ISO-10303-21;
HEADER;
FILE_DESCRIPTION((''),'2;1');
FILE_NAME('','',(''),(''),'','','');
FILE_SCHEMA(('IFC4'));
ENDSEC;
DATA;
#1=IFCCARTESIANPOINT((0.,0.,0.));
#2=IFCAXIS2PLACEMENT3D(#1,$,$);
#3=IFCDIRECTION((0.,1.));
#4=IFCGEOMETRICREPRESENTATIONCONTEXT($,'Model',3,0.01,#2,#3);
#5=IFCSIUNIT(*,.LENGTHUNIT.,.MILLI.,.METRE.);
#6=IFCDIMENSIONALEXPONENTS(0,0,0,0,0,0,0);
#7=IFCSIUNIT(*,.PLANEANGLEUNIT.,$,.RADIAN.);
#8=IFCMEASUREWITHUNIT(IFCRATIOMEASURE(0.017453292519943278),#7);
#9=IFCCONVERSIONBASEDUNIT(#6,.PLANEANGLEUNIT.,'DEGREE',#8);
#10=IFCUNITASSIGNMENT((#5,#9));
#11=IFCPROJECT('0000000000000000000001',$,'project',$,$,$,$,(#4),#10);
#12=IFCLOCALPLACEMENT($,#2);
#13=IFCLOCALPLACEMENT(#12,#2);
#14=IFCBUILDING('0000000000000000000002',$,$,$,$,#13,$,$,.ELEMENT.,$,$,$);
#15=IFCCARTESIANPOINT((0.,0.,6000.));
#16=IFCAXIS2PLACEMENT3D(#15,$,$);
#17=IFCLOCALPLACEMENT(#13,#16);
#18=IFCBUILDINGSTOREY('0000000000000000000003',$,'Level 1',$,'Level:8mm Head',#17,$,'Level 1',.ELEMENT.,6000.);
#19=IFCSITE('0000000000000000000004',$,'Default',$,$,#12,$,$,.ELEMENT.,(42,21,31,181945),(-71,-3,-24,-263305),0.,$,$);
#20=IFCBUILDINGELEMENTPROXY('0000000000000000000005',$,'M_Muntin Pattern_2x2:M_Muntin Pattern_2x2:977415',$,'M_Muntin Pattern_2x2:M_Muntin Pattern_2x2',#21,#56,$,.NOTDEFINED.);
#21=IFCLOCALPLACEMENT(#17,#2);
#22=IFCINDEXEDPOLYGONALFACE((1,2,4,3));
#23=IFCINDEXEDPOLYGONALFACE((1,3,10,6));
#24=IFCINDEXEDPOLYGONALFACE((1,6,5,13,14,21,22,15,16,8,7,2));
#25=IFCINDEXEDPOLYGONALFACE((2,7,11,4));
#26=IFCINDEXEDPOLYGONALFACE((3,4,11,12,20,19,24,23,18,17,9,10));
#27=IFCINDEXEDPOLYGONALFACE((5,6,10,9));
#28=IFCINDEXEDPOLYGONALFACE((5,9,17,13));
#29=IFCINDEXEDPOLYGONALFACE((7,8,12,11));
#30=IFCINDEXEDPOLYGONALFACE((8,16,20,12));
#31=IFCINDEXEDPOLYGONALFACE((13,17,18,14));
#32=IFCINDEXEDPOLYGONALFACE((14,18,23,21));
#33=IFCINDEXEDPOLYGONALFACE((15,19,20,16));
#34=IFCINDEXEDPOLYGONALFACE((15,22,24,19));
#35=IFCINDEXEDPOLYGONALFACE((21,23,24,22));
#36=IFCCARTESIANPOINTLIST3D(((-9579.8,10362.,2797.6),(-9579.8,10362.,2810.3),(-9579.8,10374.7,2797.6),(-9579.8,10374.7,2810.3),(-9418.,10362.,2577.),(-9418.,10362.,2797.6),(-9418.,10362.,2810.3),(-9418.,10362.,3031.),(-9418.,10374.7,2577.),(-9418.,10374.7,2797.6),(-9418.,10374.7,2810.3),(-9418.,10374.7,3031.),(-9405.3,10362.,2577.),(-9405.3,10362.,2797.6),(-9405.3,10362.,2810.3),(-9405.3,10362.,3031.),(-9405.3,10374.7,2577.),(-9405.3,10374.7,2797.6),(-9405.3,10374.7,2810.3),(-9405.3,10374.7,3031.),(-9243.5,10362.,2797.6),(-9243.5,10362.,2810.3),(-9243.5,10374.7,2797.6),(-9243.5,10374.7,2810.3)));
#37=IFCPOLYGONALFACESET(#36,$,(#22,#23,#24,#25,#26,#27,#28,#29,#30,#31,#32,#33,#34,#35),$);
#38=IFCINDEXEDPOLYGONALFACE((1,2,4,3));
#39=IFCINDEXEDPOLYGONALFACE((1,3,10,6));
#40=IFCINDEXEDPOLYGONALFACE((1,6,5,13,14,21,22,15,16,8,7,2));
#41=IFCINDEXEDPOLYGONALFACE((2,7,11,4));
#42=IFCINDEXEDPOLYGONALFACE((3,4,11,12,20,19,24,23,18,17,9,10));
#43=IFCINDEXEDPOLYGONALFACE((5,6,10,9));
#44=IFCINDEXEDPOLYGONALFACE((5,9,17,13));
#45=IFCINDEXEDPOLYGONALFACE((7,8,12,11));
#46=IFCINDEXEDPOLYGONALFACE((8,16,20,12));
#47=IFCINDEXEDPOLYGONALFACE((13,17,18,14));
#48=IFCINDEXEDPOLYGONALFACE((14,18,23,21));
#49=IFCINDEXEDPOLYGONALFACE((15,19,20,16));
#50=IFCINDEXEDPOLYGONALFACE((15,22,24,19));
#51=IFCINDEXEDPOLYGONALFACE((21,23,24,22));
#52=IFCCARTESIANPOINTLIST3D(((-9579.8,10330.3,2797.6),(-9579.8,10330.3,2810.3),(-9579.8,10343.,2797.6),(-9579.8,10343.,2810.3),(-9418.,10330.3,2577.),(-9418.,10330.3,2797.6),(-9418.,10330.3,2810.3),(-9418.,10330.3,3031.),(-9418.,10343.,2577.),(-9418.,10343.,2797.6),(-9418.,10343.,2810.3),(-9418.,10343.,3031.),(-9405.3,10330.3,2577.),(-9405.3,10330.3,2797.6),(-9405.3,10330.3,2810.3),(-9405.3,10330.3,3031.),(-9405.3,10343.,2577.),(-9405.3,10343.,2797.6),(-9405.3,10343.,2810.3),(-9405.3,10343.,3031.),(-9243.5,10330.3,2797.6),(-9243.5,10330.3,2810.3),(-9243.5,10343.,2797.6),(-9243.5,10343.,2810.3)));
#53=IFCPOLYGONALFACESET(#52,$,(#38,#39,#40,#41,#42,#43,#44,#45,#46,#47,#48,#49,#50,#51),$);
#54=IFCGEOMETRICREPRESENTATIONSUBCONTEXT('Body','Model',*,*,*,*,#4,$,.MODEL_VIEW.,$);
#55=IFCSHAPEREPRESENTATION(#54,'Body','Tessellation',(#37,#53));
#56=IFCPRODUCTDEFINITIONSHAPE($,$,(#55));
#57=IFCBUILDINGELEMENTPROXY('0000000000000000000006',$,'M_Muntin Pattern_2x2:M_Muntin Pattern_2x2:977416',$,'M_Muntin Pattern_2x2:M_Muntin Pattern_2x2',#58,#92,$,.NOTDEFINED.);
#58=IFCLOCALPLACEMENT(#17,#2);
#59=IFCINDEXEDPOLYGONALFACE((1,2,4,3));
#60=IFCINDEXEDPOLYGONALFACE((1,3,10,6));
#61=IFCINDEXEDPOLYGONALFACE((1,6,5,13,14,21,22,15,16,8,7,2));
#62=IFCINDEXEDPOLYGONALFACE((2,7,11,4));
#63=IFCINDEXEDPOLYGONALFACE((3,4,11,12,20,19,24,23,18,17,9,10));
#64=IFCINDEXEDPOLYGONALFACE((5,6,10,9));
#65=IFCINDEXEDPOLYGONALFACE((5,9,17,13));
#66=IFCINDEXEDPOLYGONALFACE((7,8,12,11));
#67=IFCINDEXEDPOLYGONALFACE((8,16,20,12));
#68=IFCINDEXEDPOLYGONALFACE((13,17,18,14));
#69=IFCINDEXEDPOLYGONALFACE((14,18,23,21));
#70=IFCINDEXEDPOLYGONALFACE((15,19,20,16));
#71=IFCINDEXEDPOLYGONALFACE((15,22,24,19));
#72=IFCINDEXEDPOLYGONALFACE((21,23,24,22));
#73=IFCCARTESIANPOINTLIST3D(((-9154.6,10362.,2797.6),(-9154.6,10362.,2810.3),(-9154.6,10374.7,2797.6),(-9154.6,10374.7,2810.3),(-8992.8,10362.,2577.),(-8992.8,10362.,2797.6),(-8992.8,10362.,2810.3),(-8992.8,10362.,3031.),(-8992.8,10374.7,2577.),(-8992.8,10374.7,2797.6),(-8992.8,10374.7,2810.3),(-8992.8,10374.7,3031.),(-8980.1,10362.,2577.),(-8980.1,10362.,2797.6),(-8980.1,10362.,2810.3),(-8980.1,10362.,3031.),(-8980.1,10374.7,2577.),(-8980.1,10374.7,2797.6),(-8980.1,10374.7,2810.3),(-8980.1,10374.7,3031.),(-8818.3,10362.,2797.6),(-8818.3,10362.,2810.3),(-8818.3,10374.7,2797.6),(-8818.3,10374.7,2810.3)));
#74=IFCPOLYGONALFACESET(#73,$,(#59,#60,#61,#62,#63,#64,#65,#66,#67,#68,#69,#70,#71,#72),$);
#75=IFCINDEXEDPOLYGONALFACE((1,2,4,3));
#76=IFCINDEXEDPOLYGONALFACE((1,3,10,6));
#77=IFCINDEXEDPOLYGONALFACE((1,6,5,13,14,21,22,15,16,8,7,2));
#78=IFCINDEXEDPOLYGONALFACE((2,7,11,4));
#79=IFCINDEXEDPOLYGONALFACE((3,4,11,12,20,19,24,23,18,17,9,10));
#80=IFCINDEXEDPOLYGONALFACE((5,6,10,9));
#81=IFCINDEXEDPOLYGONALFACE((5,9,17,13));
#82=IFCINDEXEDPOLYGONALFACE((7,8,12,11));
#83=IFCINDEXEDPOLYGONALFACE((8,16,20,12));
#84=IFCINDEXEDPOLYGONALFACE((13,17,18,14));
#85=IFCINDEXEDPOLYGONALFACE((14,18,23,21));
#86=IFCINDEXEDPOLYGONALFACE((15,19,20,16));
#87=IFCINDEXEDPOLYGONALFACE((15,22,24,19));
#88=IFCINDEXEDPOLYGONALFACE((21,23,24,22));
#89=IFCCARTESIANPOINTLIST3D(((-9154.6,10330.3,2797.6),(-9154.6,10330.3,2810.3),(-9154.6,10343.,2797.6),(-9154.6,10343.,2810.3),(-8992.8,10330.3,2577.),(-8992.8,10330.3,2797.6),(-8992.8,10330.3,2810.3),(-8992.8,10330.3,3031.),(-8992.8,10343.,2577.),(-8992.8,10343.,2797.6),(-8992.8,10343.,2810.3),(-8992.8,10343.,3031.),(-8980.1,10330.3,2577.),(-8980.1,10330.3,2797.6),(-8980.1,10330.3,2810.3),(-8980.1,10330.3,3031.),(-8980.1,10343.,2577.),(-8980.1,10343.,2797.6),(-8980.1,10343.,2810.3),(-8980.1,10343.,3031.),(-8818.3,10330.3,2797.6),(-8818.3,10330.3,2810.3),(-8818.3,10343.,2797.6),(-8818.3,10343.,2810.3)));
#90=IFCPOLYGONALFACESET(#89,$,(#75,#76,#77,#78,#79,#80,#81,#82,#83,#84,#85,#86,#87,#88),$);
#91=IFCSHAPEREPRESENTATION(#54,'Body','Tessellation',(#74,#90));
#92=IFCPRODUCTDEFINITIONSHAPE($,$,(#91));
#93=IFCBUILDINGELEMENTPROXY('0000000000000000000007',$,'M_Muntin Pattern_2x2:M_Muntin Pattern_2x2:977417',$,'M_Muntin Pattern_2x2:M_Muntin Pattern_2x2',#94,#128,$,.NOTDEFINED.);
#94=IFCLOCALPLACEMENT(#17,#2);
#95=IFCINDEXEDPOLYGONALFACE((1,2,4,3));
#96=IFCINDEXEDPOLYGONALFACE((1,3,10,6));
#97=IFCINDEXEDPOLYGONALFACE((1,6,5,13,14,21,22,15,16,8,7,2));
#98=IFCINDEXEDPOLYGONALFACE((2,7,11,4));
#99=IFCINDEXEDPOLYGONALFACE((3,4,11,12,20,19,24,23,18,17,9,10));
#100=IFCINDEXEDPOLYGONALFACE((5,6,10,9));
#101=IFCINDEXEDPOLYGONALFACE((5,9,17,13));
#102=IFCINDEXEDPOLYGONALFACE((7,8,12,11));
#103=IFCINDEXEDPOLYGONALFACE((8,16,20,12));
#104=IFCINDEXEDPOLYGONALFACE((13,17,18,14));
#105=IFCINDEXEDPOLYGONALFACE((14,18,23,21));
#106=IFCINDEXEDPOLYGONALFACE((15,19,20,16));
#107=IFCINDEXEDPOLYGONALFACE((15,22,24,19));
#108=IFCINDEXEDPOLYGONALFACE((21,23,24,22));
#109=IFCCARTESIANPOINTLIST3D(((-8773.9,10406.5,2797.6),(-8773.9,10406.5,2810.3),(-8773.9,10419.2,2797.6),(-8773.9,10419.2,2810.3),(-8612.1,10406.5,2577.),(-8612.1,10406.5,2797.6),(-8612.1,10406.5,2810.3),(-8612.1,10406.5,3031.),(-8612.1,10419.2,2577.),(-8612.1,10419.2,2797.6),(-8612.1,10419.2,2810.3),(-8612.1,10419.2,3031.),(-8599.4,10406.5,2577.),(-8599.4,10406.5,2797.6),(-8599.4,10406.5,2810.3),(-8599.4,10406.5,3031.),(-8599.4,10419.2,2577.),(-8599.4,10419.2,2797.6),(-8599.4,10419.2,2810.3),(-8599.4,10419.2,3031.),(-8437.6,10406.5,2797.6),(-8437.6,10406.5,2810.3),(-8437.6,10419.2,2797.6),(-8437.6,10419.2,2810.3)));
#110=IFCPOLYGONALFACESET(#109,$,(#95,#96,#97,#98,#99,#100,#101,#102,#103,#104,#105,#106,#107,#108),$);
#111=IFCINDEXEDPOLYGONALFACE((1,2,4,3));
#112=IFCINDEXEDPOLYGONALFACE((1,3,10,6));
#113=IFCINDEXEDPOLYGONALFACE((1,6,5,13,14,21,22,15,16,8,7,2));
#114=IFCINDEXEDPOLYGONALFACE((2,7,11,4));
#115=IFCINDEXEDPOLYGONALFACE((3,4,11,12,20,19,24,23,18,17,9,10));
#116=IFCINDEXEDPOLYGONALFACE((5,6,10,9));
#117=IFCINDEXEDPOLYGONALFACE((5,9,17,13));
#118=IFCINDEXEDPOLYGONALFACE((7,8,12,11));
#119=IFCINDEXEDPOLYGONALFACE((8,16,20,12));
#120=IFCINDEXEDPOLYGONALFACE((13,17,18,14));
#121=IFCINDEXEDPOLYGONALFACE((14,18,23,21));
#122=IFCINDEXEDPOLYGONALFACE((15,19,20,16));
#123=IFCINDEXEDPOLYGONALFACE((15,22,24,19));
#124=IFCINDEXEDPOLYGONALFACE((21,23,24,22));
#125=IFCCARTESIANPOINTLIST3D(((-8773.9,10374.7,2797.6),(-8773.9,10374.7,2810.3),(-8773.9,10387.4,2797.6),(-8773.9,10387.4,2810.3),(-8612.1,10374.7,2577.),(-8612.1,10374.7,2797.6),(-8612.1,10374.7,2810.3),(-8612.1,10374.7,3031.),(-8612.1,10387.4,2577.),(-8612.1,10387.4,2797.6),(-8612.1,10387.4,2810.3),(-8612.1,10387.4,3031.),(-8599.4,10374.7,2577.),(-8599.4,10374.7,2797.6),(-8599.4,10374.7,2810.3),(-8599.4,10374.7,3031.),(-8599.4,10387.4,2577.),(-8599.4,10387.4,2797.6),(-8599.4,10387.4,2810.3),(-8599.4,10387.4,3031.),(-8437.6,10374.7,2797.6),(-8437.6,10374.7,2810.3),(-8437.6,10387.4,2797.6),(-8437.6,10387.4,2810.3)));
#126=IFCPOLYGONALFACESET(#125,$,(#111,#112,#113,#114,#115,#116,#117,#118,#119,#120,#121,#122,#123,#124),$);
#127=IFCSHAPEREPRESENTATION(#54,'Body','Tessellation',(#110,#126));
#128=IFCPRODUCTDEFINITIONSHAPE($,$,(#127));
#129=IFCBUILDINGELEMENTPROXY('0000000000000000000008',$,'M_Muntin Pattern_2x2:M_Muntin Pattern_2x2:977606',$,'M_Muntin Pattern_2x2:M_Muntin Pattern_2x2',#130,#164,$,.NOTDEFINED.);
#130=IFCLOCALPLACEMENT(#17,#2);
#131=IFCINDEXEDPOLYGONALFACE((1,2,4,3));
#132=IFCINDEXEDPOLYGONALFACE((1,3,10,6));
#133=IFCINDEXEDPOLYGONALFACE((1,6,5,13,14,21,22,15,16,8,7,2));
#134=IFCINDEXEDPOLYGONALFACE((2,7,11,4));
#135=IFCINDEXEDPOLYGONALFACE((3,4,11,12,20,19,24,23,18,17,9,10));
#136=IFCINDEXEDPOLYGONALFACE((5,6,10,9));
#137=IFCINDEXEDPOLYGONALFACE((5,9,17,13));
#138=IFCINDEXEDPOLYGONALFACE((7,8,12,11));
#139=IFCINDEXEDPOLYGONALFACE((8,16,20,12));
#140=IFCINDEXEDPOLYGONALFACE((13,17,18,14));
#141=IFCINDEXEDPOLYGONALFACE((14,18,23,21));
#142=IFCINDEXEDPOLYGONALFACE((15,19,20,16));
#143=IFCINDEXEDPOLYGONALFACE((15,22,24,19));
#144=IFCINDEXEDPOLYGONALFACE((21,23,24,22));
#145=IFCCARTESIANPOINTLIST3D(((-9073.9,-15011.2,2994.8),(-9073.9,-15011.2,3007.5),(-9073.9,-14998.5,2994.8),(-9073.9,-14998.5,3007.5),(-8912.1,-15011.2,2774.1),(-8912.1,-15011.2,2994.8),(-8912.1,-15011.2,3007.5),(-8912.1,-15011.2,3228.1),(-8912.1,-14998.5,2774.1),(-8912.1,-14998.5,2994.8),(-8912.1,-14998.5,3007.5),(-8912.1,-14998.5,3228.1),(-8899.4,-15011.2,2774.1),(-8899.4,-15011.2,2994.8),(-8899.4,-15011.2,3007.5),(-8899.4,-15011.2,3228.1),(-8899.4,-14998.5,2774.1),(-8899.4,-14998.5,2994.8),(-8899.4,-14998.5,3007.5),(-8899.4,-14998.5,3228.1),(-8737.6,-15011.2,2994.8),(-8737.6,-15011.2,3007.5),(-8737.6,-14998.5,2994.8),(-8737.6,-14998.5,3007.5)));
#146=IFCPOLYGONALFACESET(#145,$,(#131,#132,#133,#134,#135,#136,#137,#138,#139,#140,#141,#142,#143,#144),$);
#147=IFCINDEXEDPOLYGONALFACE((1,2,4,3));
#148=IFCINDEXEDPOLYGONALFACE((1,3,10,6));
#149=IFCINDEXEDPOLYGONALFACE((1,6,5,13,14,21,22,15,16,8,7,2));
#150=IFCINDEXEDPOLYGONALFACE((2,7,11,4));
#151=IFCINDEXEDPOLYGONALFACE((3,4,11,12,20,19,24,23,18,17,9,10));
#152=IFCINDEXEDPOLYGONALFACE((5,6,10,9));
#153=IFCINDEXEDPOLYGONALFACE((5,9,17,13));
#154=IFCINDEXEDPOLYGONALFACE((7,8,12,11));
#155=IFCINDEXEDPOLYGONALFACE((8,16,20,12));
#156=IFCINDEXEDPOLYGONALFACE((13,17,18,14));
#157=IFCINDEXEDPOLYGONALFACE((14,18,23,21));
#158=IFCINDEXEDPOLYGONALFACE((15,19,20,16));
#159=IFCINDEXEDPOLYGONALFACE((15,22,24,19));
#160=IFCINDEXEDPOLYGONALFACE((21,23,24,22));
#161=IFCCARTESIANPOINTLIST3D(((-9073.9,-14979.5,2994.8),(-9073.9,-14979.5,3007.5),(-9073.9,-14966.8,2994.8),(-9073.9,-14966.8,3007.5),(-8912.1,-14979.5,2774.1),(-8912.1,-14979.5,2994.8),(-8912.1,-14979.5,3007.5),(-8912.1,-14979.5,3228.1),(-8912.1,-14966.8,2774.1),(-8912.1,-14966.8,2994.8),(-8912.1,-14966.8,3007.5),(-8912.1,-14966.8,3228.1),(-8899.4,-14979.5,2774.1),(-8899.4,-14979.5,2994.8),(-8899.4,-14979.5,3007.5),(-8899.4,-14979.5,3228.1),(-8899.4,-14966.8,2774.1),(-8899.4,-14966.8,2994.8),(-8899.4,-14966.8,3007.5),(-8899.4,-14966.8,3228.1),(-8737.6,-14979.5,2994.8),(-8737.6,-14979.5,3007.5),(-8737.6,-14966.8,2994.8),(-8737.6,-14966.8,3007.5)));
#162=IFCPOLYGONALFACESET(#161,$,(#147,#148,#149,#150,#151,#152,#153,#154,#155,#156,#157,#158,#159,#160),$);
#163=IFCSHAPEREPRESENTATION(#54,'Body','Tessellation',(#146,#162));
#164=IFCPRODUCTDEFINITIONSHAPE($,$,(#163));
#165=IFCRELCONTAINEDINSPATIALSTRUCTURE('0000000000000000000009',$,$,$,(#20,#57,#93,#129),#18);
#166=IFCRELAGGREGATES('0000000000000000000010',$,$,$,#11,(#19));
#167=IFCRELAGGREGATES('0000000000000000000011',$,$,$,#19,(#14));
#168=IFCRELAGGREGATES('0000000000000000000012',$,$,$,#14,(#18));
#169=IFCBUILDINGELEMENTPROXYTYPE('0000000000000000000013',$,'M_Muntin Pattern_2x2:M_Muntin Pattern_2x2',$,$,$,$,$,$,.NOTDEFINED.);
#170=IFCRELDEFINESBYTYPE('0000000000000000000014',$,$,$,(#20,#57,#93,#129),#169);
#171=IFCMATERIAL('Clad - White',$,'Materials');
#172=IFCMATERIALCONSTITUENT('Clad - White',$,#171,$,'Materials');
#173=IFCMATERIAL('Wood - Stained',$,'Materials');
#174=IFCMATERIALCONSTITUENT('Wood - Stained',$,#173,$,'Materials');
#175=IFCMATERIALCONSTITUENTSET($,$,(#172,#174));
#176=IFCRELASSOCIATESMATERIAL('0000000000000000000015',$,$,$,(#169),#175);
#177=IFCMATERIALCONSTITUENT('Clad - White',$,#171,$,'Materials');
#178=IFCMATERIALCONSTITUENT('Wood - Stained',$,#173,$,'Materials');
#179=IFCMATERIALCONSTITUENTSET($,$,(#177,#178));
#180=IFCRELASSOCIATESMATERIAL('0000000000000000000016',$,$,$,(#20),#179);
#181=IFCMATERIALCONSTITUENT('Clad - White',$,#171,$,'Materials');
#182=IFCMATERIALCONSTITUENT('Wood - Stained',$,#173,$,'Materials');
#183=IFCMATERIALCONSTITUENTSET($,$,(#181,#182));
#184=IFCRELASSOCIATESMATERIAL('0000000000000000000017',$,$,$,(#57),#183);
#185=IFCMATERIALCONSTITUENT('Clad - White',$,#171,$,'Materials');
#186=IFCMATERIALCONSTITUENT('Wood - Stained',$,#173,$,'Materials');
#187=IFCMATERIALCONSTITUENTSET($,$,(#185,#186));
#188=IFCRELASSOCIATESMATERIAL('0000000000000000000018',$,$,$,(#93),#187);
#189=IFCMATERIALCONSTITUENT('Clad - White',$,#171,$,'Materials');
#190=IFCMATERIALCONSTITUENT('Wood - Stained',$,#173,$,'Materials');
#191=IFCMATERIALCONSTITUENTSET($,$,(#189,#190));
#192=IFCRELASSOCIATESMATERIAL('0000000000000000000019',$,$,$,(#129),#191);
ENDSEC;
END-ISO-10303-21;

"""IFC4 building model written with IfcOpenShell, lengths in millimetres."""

from ifc_helpers import new_model, entity, si_unit, converted_unit, direction, frame, origin, place, context, subcontext, project, spatial, polyline, outline, extrude, source, transform, mapped, material, constituent, constituent_set, type_object, type_shapes, element, save


model = new_model("IFC4")

# Units and contexts
model_context = context("Model", 3, precision=0.01, world=origin(), true_north=direction((0.0, 1.0)))
body_context = subcontext(model_context, "Body", "Model", "MODEL_VIEW")
ifc_project = project(units=[si_unit("LENGTHUNIT", "METRE", prefix="MILLI"), converted_unit("PLANEANGLEUNIT", "DEGREE", entity("IfcRatioMeasure", 0.017453292519943278), si_unit("PLANEANGLEUNIT", "RADIAN"), dimensions=[0, 0, 0, 0, 0, 0, 0])], contexts=[model_context])

# Site, building, storey
site_placement = place(None, origin())
site = spatial("IfcSite", under=ifc_project, at=site_placement, Name="Default", CompositionType="ELEMENT", RefLatitude=(42, 21, 31, 181945), RefLongitude=(-71, -3, -24, -263305), RefElevation=0.0)
building_placement = place(site_placement, origin())
building = spatial("IfcBuilding", under=site, at=building_placement, CompositionType="ELEMENT")
storey_placement = place(building_placement, frame((0.0, 0.0, 6000.0)))
storey = spatial("IfcBuildingStorey", under=building, at=storey_placement, Name="Level 1", ObjectType="Level:8mm Head", LongName="Level 1", CompositionType="ELEMENT", Elevation=6000.0)

# Building element proxies
ifc_material_1 = material(Name="Clad - White", Category="Materials")
ifc_material_2 = material(Name="Wood - Stained", Category="Materials")
ifc_constituent_1 = constituent(ifc_material_1, Name="Clad - White", Category="Materials")
ifc_constituent_2 = constituent(ifc_material_2, Name="Wood - Stained", Category="Materials")
ifc_constituent_set_1 = constituent_set(constituents=[ifc_constituent_1, ifc_constituent_2])
building_element_proxy_type_1 = type_object("IfcBuildingElementProxyType", Name="M_Muntin Pattern_2x2:M_Muntin Pattern_2x2", PredefinedType="NOTDEFINED", material=ifc_constituent_set_1)
shared_shape_1 = source(origin(), body_context, "Body", "SweptSolid", [
    extrude(outline(polyline([(6.4, -6.4), (227.0, -6.4), (227.0, 6.3), (6.4, 6.3), (6.4, 168.2), (-6.3, 168.2), (-6.3, 6.3), (-227.0, 6.3), (-227.0, -6.4), (-6.3, -6.4), (-6.3, -168.1), (6.4, -168.1), (6.4, -6.4)])), frame((0.0, 9.5, 227.0), z_axis=(0.0, 1.0, 0.0), x_axis=(0.0, 0.0, 1.0)), (0.0, 0.0, 1.0), 12.7),
    extrude(outline(polyline([(6.4, -6.4), (227.0, -6.4), (227.0, 6.3), (6.4, 6.3), (6.4, 168.2), (-6.3, 168.2), (-6.3, 6.3), (-227.0, 6.3), (-227.0, -6.4), (-6.3, -6.4), (-6.3, -168.1), (6.4, -168.1), (6.4, -6.4)])), frame((0.0, -22.2, 227.0), z_axis=(0.0, 1.0, 0.0), x_axis=(0.0, 0.0, 1.0)), (0.0, 0.0, 1.0), 12.7),
])
type_shapes(building_element_proxy_type_1, [shared_shape_1])
ifc_constituent_3 = constituent(ifc_material_1, Name="Clad - White", Category="Materials")
ifc_constituent_4 = constituent(ifc_material_2, Name="Wood - Stained", Category="Materials")
ifc_constituent_set_2 = constituent_set(constituents=[ifc_constituent_3, ifc_constituent_4])
proxy_1_placement = place(storey_placement, frame((-9411.7, 10352.5, 2577.0)))
element("IfcBuildingElementProxy", 1, at=proxy_1_placement, inside=storey, type_object=building_element_proxy_type_1, material=ifc_constituent_set_2, Name="M_Muntin Pattern_2x2:M_Muntin Pattern_2x2:977415", ObjectType="M_Muntin Pattern_2x2:M_Muntin Pattern_2x2", PredefinedType="NOTDEFINED", context=body_context, shape_type="MappedRepresentation", body=[
    mapped(shared_shape_1, transform((0.0, 0.0, 0.0), scale=1.0)),
])
ifc_constituent_5 = constituent(ifc_material_1, Name="Clad - White", Category="Materials")
ifc_constituent_6 = constituent(ifc_material_2, Name="Wood - Stained", Category="Materials")
ifc_constituent_set_3 = constituent_set(constituents=[ifc_constituent_5, ifc_constituent_6])
proxy_2_placement = place(storey_placement, frame((-8986.5, 10352.5, 2577.0)))
element("IfcBuildingElementProxy", 2, at=proxy_2_placement, inside=storey, type_object=building_element_proxy_type_1, material=ifc_constituent_set_3, Name="M_Muntin Pattern_2x2:M_Muntin Pattern_2x2:977416", ObjectType="M_Muntin Pattern_2x2:M_Muntin Pattern_2x2", PredefinedType="NOTDEFINED", context=body_context, shape_type="MappedRepresentation", body=[
    mapped(shared_shape_1, transform((0.0, 0.0, 0.0), scale=1.0)),
])
ifc_constituent_7 = constituent(ifc_material_1, Name="Clad - White", Category="Materials")
ifc_constituent_8 = constituent(ifc_material_2, Name="Wood - Stained", Category="Materials")
ifc_constituent_set_4 = constituent_set(constituents=[ifc_constituent_7, ifc_constituent_8])
proxy_3_placement = place(storey_placement, frame((-8605.7, 10396.9, 2577.0)))
element("IfcBuildingElementProxy", 3, at=proxy_3_placement, inside=storey, type_object=building_element_proxy_type_1, material=ifc_constituent_set_4, Name="M_Muntin Pattern_2x2:M_Muntin Pattern_2x2:977417", ObjectType="M_Muntin Pattern_2x2:M_Muntin Pattern_2x2", PredefinedType="NOTDEFINED", context=body_context, shape_type="MappedRepresentation", body=[
    mapped(shared_shape_1, transform((0.0, 0.0, 0.0), scale=1.0)),
])
ifc_constituent_9 = constituent(ifc_material_1, Name="Clad - White", Category="Materials")
ifc_constituent_10 = constituent(ifc_material_2, Name="Wood - Stained", Category="Materials")
ifc_constituent_set_5 = constituent_set(constituents=[ifc_constituent_9, ifc_constituent_10])
proxy_4_placement = place(storey_placement, frame((-8905.7, -14989.0, 2774.1), z_axis=(0.0, 0.0, 1.0), x_axis=(-1.0, 0.0, 0.0)))
element("IfcBuildingElementProxy", 4, at=proxy_4_placement, inside=storey, type_object=building_element_proxy_type_1, material=ifc_constituent_set_5, Name="M_Muntin Pattern_2x2:M_Muntin Pattern_2x2:977606", ObjectType="M_Muntin Pattern_2x2:M_Muntin Pattern_2x2", PredefinedType="NOTDEFINED", context=body_context, shape_type="MappedRepresentation", body=[
    mapped(shared_shape_1, transform((0.0, 0.0, 0.0), scale=1.0)),
])

save(model, "model.ifc")
